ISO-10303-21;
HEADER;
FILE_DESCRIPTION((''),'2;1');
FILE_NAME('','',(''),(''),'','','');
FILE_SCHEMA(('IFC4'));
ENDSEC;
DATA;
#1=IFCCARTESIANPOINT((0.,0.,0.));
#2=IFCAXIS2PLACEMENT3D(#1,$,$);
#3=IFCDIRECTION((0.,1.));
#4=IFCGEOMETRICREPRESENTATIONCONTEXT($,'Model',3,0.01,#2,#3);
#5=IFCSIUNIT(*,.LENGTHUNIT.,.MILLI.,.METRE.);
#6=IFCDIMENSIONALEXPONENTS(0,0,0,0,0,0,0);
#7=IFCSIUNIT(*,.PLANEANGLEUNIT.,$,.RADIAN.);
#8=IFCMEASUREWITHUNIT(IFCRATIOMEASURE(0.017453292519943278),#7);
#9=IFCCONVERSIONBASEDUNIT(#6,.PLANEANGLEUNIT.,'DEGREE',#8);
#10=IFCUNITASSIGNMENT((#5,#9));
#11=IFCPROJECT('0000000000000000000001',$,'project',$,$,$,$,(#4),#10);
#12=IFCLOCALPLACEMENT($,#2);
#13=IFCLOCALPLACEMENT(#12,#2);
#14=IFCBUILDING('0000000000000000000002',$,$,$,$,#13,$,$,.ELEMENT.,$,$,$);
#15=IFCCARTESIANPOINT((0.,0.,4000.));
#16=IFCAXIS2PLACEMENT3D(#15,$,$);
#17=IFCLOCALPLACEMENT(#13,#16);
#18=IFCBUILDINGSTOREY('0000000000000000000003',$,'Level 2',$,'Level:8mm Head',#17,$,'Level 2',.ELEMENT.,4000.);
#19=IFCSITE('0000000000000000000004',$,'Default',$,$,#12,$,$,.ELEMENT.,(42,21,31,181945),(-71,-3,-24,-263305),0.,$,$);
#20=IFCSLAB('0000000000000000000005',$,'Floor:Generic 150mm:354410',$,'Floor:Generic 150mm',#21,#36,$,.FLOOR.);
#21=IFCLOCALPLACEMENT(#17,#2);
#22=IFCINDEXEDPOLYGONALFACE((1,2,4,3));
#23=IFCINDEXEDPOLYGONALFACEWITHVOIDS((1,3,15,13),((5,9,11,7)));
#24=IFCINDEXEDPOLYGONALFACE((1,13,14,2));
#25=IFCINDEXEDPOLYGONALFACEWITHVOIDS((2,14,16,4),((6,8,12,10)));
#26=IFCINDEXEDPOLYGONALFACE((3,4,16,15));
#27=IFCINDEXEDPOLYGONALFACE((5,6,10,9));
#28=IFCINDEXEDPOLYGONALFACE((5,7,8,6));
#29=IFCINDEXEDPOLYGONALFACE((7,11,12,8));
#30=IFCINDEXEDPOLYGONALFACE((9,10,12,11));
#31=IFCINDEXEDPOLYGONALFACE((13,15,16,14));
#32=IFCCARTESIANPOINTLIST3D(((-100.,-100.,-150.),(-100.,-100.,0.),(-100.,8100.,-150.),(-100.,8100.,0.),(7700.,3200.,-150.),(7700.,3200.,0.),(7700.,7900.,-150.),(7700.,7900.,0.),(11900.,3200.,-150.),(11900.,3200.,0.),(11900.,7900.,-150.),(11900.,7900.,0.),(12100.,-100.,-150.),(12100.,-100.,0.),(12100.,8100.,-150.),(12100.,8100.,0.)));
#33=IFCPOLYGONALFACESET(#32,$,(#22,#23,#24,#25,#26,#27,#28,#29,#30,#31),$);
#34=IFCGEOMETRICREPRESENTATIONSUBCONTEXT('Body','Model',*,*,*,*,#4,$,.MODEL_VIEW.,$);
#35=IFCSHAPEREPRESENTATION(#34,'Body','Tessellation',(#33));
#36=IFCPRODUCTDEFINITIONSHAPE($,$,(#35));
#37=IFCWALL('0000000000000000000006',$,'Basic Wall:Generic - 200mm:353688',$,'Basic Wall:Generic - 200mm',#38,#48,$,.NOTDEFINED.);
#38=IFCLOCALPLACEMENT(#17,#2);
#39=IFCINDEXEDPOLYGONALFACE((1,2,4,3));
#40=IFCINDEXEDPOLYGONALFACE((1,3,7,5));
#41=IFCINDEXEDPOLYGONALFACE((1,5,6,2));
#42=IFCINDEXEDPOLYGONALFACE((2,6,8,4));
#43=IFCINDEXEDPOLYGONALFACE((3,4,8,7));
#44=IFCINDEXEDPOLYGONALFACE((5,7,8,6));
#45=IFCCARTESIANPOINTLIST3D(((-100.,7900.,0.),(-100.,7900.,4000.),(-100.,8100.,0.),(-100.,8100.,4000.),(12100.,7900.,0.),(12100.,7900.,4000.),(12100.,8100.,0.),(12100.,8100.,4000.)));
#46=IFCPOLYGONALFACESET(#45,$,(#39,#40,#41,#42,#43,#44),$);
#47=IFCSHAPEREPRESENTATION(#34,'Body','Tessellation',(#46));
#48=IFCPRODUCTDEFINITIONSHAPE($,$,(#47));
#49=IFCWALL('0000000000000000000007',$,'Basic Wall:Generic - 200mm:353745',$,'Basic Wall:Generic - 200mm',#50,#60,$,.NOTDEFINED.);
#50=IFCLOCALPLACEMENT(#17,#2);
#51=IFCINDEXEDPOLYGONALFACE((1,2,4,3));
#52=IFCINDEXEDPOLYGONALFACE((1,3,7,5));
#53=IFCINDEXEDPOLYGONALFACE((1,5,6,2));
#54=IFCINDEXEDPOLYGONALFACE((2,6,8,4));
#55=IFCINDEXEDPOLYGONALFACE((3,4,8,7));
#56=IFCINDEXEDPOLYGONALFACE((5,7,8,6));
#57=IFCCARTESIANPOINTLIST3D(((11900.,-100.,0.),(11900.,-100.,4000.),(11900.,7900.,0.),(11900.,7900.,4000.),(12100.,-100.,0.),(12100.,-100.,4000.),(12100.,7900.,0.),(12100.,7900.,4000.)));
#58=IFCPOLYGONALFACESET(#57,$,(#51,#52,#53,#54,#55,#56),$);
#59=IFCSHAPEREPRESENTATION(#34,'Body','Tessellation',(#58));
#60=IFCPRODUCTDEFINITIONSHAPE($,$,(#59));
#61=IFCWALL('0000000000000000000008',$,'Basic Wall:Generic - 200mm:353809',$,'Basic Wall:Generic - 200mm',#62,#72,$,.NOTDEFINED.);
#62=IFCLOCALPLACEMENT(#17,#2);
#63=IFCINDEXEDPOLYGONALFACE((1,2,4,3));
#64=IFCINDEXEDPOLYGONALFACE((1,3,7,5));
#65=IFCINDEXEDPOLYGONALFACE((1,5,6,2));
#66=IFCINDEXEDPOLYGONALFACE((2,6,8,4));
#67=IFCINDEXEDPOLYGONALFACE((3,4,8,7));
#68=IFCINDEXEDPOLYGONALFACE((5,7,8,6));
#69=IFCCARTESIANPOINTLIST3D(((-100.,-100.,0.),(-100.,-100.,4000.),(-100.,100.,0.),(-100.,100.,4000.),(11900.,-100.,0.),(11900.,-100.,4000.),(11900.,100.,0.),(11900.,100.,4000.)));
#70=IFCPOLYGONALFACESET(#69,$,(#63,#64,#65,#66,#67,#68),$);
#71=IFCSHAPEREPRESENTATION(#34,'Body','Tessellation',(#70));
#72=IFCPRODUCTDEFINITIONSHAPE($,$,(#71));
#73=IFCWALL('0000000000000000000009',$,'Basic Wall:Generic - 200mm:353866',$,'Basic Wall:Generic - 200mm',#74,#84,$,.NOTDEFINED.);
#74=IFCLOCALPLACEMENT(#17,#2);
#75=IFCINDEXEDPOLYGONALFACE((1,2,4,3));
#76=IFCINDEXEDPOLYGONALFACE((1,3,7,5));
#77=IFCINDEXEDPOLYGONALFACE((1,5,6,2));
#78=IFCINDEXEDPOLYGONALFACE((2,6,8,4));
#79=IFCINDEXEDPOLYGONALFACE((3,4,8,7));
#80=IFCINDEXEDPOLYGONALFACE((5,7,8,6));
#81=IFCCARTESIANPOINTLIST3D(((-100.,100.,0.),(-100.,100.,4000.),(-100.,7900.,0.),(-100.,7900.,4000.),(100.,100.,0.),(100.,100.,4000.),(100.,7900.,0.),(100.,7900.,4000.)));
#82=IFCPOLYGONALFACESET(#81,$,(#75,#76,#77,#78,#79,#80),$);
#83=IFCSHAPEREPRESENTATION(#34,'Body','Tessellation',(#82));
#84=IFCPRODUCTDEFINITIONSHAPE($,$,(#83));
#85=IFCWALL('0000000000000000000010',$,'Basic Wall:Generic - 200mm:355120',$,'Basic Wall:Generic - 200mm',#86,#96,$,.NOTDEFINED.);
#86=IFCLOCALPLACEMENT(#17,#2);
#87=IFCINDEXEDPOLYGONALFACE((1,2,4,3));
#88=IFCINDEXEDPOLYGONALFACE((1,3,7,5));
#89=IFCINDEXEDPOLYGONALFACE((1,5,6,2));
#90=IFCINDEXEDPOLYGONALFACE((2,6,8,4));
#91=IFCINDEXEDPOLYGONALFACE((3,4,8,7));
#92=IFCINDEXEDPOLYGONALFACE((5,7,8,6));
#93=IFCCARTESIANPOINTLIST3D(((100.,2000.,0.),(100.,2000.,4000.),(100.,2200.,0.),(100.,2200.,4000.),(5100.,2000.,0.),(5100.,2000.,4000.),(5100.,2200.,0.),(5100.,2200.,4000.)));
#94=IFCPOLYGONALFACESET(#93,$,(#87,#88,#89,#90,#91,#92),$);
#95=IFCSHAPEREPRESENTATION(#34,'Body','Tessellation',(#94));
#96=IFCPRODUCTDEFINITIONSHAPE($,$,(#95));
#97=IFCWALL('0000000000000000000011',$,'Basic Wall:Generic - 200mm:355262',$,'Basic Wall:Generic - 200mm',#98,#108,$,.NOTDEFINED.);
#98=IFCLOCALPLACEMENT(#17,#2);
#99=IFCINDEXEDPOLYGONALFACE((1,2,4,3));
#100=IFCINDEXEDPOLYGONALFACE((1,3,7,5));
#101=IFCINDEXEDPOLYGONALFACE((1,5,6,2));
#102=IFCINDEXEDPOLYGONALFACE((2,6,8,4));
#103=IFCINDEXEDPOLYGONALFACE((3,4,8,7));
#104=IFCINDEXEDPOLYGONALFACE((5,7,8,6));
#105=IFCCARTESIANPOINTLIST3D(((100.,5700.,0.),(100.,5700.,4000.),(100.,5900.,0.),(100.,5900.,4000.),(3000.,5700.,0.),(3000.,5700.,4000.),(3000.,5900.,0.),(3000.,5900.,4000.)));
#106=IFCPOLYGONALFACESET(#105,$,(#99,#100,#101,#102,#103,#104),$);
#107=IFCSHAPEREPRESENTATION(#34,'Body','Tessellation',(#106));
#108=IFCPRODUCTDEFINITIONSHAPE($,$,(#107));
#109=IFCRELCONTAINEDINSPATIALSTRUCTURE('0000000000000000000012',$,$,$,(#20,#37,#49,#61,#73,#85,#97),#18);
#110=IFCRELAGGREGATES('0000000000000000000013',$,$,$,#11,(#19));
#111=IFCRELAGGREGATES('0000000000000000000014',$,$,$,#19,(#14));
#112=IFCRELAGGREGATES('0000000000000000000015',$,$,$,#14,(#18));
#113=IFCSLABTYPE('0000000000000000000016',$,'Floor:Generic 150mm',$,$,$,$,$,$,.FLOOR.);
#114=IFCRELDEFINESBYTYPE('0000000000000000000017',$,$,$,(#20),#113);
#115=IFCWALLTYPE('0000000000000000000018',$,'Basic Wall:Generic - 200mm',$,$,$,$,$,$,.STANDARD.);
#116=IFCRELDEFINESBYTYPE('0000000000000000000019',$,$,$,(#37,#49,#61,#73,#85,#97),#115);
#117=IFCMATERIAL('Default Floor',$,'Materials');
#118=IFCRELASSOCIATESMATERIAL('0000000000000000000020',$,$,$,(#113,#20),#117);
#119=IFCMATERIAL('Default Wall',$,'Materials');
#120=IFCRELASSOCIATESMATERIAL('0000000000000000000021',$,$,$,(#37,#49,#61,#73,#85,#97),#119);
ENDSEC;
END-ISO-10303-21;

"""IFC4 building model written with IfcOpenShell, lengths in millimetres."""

from ifc_helpers import new_model, entity, si_unit, converted_unit, direction, frame, origin, place, context, subcontext, project, spatial, indexed_curve, outline, extrude, material, type_object, element, save


model = new_model("IFC4")

# Units and contexts
model_context = context("Model", 3, precision=0.01, world=origin(), true_north=direction((0.0, 1.0)))
body_context = subcontext(model_context, "Body", "Model", "MODEL_VIEW")
ifc_project = project(units=[si_unit("LENGTHUNIT", "METRE", prefix="MILLI"), converted_unit("PLANEANGLEUNIT", "DEGREE", entity("IfcRatioMeasure", 0.017453292519943278), si_unit("PLANEANGLEUNIT", "RADIAN"), dimensions=[0, 0, 0, 0, 0, 0, 0])], contexts=[model_context])

# Site, building, storey
site_placement = place(None, origin())
site = spatial("IfcSite", under=ifc_project, at=site_placement, Name="Default", CompositionType="ELEMENT", RefLatitude=(42, 21, 31, 181945), RefLongitude=(-71, -3, -24, -263305), RefElevation=0.0)
building_placement = place(site_placement, origin())
building = spatial("IfcBuilding", under=site, at=building_placement, CompositionType="ELEMENT")
storey_placement = place(building_placement, frame((0.0, 0.0, 4000.0)))
storey = spatial("IfcBuildingStorey", under=building, at=storey_placement, Name="Level 2", ObjectType="Level:8mm Head", LongName="Level 2", CompositionType="ELEMENT", Elevation=4000.0)

# Slab, opening
ifc_material_1 = material(Name="Default Floor", Category="Materials")
slab_type = type_object("IfcSlabType", Name="Floor:Generic 150mm", PredefinedType="FLOOR", material=ifc_material_1)
slab_placement = place(storey_placement, origin())
slab = element("IfcSlab", 1, at=slab_placement, inside=storey, type_object=slab_type, material=ifc_material_1, Name="Floor:Generic 150mm:354410", ObjectType="Floor:Generic 150mm", PredefinedType="FLOOR", context=body_context, shape_type="SweptSolid", body=[
    extrude(outline(indexed_curve([(-6100.0, -4100.0), (6100.0, -4100.0), (6100.0, 4100.0), (-6100.0, 4100.0), (-6100.0, -4100.0)], self_intersect=False), holes=[indexed_curve([(-5900.0, -3900.0), (-5900.0, 800.0), (-1700.0, 800.0), (-1700.0, -3900.0), (-5900.0, -3900.0)], self_intersect=False)]), frame((6000.0, 4000.0, -150.0), z_axis=(0.0, 0.0, 1.0), x_axis=(-1.0, 0.0, 0.0)), (0.0, 0.0, 1.0), 150.0),
])
opening_placement = place(slab_placement, origin())
element("IfcOpeningElement", 2, at=opening_placement, cuts=slab, PredefinedType="OPENING", context=body_context, shape_type="SweptSolid", body=[
    extrude(outline(indexed_curve([(-2350.0, -2100.0), (2350.0, -2100.0), (2350.0, 2100.0), (-2350.0, 2100.0), (-2350.0, -2100.0)], self_intersect=False)), frame((9800.0, 5550.0, 0.0), z_axis=(0.0, 0.0, -1.0), x_axis=(0.0, -1.0, 0.0)), (0.0, 0.0, 1.0), 8200.0),
])

# Walls
ifc_material_2 = material(Name="Default Wall", Category="Materials")
wall_type = type_object("IfcWallType", Name="Basic Wall:Generic - 200mm", PredefinedType="STANDARD")
wall_1_placement = place(storey_placement, frame((-100.0, 8000.0, 0.0)))
element("IfcWall", 3, at=wall_1_placement, inside=storey, type_object=wall_type, material=ifc_material_2, Name="Basic Wall:Generic - 200mm:353688", ObjectType="Basic Wall:Generic - 200mm", PredefinedType="NOTDEFINED", context=body_context, shape_type="SweptSolid", body=[
    extrude(outline(indexed_curve([(12200.0, 100.0), (0.0, 100.0), (0.0, -100.0), (12200.0, -100.0), (12200.0, 100.0)], self_intersect=False)), origin(), (0.0, 0.0, 1.0), 4000.0),
])
wall_2_placement = place(storey_placement, frame((12000.0, 7900.0, 0.0), z_axis=(0.0, 0.0, 1.0), x_axis=(0.0, -1.0, 0.0)))
element("IfcWall", 4, at=wall_2_placement, inside=storey, type_object=wall_type, material=ifc_material_2, Name="Basic Wall:Generic - 200mm:353745", ObjectType="Basic Wall:Generic - 200mm", PredefinedType="NOTDEFINED", context=body_context, shape_type="SweptSolid", body=[
    extrude(outline(indexed_curve([(8000.0, 100.0), (0.0, 100.0), (0.0, -100.0), (8000.0, -100.0), (8000.0, 100.0)], self_intersect=False)), origin(), (0.0, 0.0, 1.0), 4000.0),
])
wall_3_placement = place(storey_placement, frame((11900.0, 0.0, 0.0), z_axis=(0.0, 0.0, 1.0), x_axis=(-1.0, 0.0, 0.0)))
element("IfcWall", 5, at=wall_3_placement, inside=storey, type_object=wall_type, material=ifc_material_2, Name="Basic Wall:Generic - 200mm:353809", ObjectType="Basic Wall:Generic - 200mm", PredefinedType="NOTDEFINED", context=body_context, shape_type="SweptSolid", body=[
    extrude(outline(indexed_curve([(12000.0, 100.0), (0.0, 100.0), (0.0, -100.0), (12000.0, -100.0), (12000.0, 100.0)], self_intersect=False)), origin(), (0.0, 0.0, 1.0), 4000.0),
])
wall_4_placement = place(storey_placement, frame((0.0, 100.0, 0.0), z_axis=(0.0, 0.0, 1.0), x_axis=(0.0, 1.0, 0.0)))
element("IfcWall", 6, at=wall_4_placement, inside=storey, type_object=wall_type, material=ifc_material_2, Name="Basic Wall:Generic - 200mm:353866", ObjectType="Basic Wall:Generic - 200mm", PredefinedType="NOTDEFINED", context=body_context, shape_type="SweptSolid", body=[
    extrude(outline(indexed_curve([(7800.0, 100.0), (0.0, 100.0), (0.0, -100.0), (7800.0, -100.0), (7800.0, 100.0)], self_intersect=False)), origin(), (0.0, 0.0, 1.0), 4000.0),
])
wall_5_placement = place(storey_placement, frame((100.0, 2100.0, 0.0)))
element("IfcWall", 7, at=wall_5_placement, inside=storey, type_object=wall_type, material=ifc_material_2, Name="Basic Wall:Generic - 200mm:355120", ObjectType="Basic Wall:Generic - 200mm", PredefinedType="NOTDEFINED", context=body_context, shape_type="SweptSolid", body=[
    extrude(outline(indexed_curve([(5000.0, 100.0), (0.0, 100.0), (0.0, -100.0), (5000.0, -100.0), (5000.0, 100.0)], self_intersect=False)), origin(), (0.0, 0.0, 1.0), 4000.0),
])
wall_6_placement = place(storey_placement, frame((100.0, 5800.0, 0.0)))
element("IfcWall", 8, at=wall_6_placement, inside=storey, type_object=wall_type, material=ifc_material_2, Name="Basic Wall:Generic - 200mm:355262", ObjectType="Basic Wall:Generic - 200mm", PredefinedType="NOTDEFINED", context=body_context, shape_type="SweptSolid", body=[
    extrude(outline(indexed_curve([(2900.0, 100.0), (0.0, 100.0), (0.0, -100.0), (2900.0, -100.0), (2900.0, 100.0)], self_intersect=False)), origin(), (0.0, 0.0, 1.0), 4000.0),
])

save(model, "model.ifc")
